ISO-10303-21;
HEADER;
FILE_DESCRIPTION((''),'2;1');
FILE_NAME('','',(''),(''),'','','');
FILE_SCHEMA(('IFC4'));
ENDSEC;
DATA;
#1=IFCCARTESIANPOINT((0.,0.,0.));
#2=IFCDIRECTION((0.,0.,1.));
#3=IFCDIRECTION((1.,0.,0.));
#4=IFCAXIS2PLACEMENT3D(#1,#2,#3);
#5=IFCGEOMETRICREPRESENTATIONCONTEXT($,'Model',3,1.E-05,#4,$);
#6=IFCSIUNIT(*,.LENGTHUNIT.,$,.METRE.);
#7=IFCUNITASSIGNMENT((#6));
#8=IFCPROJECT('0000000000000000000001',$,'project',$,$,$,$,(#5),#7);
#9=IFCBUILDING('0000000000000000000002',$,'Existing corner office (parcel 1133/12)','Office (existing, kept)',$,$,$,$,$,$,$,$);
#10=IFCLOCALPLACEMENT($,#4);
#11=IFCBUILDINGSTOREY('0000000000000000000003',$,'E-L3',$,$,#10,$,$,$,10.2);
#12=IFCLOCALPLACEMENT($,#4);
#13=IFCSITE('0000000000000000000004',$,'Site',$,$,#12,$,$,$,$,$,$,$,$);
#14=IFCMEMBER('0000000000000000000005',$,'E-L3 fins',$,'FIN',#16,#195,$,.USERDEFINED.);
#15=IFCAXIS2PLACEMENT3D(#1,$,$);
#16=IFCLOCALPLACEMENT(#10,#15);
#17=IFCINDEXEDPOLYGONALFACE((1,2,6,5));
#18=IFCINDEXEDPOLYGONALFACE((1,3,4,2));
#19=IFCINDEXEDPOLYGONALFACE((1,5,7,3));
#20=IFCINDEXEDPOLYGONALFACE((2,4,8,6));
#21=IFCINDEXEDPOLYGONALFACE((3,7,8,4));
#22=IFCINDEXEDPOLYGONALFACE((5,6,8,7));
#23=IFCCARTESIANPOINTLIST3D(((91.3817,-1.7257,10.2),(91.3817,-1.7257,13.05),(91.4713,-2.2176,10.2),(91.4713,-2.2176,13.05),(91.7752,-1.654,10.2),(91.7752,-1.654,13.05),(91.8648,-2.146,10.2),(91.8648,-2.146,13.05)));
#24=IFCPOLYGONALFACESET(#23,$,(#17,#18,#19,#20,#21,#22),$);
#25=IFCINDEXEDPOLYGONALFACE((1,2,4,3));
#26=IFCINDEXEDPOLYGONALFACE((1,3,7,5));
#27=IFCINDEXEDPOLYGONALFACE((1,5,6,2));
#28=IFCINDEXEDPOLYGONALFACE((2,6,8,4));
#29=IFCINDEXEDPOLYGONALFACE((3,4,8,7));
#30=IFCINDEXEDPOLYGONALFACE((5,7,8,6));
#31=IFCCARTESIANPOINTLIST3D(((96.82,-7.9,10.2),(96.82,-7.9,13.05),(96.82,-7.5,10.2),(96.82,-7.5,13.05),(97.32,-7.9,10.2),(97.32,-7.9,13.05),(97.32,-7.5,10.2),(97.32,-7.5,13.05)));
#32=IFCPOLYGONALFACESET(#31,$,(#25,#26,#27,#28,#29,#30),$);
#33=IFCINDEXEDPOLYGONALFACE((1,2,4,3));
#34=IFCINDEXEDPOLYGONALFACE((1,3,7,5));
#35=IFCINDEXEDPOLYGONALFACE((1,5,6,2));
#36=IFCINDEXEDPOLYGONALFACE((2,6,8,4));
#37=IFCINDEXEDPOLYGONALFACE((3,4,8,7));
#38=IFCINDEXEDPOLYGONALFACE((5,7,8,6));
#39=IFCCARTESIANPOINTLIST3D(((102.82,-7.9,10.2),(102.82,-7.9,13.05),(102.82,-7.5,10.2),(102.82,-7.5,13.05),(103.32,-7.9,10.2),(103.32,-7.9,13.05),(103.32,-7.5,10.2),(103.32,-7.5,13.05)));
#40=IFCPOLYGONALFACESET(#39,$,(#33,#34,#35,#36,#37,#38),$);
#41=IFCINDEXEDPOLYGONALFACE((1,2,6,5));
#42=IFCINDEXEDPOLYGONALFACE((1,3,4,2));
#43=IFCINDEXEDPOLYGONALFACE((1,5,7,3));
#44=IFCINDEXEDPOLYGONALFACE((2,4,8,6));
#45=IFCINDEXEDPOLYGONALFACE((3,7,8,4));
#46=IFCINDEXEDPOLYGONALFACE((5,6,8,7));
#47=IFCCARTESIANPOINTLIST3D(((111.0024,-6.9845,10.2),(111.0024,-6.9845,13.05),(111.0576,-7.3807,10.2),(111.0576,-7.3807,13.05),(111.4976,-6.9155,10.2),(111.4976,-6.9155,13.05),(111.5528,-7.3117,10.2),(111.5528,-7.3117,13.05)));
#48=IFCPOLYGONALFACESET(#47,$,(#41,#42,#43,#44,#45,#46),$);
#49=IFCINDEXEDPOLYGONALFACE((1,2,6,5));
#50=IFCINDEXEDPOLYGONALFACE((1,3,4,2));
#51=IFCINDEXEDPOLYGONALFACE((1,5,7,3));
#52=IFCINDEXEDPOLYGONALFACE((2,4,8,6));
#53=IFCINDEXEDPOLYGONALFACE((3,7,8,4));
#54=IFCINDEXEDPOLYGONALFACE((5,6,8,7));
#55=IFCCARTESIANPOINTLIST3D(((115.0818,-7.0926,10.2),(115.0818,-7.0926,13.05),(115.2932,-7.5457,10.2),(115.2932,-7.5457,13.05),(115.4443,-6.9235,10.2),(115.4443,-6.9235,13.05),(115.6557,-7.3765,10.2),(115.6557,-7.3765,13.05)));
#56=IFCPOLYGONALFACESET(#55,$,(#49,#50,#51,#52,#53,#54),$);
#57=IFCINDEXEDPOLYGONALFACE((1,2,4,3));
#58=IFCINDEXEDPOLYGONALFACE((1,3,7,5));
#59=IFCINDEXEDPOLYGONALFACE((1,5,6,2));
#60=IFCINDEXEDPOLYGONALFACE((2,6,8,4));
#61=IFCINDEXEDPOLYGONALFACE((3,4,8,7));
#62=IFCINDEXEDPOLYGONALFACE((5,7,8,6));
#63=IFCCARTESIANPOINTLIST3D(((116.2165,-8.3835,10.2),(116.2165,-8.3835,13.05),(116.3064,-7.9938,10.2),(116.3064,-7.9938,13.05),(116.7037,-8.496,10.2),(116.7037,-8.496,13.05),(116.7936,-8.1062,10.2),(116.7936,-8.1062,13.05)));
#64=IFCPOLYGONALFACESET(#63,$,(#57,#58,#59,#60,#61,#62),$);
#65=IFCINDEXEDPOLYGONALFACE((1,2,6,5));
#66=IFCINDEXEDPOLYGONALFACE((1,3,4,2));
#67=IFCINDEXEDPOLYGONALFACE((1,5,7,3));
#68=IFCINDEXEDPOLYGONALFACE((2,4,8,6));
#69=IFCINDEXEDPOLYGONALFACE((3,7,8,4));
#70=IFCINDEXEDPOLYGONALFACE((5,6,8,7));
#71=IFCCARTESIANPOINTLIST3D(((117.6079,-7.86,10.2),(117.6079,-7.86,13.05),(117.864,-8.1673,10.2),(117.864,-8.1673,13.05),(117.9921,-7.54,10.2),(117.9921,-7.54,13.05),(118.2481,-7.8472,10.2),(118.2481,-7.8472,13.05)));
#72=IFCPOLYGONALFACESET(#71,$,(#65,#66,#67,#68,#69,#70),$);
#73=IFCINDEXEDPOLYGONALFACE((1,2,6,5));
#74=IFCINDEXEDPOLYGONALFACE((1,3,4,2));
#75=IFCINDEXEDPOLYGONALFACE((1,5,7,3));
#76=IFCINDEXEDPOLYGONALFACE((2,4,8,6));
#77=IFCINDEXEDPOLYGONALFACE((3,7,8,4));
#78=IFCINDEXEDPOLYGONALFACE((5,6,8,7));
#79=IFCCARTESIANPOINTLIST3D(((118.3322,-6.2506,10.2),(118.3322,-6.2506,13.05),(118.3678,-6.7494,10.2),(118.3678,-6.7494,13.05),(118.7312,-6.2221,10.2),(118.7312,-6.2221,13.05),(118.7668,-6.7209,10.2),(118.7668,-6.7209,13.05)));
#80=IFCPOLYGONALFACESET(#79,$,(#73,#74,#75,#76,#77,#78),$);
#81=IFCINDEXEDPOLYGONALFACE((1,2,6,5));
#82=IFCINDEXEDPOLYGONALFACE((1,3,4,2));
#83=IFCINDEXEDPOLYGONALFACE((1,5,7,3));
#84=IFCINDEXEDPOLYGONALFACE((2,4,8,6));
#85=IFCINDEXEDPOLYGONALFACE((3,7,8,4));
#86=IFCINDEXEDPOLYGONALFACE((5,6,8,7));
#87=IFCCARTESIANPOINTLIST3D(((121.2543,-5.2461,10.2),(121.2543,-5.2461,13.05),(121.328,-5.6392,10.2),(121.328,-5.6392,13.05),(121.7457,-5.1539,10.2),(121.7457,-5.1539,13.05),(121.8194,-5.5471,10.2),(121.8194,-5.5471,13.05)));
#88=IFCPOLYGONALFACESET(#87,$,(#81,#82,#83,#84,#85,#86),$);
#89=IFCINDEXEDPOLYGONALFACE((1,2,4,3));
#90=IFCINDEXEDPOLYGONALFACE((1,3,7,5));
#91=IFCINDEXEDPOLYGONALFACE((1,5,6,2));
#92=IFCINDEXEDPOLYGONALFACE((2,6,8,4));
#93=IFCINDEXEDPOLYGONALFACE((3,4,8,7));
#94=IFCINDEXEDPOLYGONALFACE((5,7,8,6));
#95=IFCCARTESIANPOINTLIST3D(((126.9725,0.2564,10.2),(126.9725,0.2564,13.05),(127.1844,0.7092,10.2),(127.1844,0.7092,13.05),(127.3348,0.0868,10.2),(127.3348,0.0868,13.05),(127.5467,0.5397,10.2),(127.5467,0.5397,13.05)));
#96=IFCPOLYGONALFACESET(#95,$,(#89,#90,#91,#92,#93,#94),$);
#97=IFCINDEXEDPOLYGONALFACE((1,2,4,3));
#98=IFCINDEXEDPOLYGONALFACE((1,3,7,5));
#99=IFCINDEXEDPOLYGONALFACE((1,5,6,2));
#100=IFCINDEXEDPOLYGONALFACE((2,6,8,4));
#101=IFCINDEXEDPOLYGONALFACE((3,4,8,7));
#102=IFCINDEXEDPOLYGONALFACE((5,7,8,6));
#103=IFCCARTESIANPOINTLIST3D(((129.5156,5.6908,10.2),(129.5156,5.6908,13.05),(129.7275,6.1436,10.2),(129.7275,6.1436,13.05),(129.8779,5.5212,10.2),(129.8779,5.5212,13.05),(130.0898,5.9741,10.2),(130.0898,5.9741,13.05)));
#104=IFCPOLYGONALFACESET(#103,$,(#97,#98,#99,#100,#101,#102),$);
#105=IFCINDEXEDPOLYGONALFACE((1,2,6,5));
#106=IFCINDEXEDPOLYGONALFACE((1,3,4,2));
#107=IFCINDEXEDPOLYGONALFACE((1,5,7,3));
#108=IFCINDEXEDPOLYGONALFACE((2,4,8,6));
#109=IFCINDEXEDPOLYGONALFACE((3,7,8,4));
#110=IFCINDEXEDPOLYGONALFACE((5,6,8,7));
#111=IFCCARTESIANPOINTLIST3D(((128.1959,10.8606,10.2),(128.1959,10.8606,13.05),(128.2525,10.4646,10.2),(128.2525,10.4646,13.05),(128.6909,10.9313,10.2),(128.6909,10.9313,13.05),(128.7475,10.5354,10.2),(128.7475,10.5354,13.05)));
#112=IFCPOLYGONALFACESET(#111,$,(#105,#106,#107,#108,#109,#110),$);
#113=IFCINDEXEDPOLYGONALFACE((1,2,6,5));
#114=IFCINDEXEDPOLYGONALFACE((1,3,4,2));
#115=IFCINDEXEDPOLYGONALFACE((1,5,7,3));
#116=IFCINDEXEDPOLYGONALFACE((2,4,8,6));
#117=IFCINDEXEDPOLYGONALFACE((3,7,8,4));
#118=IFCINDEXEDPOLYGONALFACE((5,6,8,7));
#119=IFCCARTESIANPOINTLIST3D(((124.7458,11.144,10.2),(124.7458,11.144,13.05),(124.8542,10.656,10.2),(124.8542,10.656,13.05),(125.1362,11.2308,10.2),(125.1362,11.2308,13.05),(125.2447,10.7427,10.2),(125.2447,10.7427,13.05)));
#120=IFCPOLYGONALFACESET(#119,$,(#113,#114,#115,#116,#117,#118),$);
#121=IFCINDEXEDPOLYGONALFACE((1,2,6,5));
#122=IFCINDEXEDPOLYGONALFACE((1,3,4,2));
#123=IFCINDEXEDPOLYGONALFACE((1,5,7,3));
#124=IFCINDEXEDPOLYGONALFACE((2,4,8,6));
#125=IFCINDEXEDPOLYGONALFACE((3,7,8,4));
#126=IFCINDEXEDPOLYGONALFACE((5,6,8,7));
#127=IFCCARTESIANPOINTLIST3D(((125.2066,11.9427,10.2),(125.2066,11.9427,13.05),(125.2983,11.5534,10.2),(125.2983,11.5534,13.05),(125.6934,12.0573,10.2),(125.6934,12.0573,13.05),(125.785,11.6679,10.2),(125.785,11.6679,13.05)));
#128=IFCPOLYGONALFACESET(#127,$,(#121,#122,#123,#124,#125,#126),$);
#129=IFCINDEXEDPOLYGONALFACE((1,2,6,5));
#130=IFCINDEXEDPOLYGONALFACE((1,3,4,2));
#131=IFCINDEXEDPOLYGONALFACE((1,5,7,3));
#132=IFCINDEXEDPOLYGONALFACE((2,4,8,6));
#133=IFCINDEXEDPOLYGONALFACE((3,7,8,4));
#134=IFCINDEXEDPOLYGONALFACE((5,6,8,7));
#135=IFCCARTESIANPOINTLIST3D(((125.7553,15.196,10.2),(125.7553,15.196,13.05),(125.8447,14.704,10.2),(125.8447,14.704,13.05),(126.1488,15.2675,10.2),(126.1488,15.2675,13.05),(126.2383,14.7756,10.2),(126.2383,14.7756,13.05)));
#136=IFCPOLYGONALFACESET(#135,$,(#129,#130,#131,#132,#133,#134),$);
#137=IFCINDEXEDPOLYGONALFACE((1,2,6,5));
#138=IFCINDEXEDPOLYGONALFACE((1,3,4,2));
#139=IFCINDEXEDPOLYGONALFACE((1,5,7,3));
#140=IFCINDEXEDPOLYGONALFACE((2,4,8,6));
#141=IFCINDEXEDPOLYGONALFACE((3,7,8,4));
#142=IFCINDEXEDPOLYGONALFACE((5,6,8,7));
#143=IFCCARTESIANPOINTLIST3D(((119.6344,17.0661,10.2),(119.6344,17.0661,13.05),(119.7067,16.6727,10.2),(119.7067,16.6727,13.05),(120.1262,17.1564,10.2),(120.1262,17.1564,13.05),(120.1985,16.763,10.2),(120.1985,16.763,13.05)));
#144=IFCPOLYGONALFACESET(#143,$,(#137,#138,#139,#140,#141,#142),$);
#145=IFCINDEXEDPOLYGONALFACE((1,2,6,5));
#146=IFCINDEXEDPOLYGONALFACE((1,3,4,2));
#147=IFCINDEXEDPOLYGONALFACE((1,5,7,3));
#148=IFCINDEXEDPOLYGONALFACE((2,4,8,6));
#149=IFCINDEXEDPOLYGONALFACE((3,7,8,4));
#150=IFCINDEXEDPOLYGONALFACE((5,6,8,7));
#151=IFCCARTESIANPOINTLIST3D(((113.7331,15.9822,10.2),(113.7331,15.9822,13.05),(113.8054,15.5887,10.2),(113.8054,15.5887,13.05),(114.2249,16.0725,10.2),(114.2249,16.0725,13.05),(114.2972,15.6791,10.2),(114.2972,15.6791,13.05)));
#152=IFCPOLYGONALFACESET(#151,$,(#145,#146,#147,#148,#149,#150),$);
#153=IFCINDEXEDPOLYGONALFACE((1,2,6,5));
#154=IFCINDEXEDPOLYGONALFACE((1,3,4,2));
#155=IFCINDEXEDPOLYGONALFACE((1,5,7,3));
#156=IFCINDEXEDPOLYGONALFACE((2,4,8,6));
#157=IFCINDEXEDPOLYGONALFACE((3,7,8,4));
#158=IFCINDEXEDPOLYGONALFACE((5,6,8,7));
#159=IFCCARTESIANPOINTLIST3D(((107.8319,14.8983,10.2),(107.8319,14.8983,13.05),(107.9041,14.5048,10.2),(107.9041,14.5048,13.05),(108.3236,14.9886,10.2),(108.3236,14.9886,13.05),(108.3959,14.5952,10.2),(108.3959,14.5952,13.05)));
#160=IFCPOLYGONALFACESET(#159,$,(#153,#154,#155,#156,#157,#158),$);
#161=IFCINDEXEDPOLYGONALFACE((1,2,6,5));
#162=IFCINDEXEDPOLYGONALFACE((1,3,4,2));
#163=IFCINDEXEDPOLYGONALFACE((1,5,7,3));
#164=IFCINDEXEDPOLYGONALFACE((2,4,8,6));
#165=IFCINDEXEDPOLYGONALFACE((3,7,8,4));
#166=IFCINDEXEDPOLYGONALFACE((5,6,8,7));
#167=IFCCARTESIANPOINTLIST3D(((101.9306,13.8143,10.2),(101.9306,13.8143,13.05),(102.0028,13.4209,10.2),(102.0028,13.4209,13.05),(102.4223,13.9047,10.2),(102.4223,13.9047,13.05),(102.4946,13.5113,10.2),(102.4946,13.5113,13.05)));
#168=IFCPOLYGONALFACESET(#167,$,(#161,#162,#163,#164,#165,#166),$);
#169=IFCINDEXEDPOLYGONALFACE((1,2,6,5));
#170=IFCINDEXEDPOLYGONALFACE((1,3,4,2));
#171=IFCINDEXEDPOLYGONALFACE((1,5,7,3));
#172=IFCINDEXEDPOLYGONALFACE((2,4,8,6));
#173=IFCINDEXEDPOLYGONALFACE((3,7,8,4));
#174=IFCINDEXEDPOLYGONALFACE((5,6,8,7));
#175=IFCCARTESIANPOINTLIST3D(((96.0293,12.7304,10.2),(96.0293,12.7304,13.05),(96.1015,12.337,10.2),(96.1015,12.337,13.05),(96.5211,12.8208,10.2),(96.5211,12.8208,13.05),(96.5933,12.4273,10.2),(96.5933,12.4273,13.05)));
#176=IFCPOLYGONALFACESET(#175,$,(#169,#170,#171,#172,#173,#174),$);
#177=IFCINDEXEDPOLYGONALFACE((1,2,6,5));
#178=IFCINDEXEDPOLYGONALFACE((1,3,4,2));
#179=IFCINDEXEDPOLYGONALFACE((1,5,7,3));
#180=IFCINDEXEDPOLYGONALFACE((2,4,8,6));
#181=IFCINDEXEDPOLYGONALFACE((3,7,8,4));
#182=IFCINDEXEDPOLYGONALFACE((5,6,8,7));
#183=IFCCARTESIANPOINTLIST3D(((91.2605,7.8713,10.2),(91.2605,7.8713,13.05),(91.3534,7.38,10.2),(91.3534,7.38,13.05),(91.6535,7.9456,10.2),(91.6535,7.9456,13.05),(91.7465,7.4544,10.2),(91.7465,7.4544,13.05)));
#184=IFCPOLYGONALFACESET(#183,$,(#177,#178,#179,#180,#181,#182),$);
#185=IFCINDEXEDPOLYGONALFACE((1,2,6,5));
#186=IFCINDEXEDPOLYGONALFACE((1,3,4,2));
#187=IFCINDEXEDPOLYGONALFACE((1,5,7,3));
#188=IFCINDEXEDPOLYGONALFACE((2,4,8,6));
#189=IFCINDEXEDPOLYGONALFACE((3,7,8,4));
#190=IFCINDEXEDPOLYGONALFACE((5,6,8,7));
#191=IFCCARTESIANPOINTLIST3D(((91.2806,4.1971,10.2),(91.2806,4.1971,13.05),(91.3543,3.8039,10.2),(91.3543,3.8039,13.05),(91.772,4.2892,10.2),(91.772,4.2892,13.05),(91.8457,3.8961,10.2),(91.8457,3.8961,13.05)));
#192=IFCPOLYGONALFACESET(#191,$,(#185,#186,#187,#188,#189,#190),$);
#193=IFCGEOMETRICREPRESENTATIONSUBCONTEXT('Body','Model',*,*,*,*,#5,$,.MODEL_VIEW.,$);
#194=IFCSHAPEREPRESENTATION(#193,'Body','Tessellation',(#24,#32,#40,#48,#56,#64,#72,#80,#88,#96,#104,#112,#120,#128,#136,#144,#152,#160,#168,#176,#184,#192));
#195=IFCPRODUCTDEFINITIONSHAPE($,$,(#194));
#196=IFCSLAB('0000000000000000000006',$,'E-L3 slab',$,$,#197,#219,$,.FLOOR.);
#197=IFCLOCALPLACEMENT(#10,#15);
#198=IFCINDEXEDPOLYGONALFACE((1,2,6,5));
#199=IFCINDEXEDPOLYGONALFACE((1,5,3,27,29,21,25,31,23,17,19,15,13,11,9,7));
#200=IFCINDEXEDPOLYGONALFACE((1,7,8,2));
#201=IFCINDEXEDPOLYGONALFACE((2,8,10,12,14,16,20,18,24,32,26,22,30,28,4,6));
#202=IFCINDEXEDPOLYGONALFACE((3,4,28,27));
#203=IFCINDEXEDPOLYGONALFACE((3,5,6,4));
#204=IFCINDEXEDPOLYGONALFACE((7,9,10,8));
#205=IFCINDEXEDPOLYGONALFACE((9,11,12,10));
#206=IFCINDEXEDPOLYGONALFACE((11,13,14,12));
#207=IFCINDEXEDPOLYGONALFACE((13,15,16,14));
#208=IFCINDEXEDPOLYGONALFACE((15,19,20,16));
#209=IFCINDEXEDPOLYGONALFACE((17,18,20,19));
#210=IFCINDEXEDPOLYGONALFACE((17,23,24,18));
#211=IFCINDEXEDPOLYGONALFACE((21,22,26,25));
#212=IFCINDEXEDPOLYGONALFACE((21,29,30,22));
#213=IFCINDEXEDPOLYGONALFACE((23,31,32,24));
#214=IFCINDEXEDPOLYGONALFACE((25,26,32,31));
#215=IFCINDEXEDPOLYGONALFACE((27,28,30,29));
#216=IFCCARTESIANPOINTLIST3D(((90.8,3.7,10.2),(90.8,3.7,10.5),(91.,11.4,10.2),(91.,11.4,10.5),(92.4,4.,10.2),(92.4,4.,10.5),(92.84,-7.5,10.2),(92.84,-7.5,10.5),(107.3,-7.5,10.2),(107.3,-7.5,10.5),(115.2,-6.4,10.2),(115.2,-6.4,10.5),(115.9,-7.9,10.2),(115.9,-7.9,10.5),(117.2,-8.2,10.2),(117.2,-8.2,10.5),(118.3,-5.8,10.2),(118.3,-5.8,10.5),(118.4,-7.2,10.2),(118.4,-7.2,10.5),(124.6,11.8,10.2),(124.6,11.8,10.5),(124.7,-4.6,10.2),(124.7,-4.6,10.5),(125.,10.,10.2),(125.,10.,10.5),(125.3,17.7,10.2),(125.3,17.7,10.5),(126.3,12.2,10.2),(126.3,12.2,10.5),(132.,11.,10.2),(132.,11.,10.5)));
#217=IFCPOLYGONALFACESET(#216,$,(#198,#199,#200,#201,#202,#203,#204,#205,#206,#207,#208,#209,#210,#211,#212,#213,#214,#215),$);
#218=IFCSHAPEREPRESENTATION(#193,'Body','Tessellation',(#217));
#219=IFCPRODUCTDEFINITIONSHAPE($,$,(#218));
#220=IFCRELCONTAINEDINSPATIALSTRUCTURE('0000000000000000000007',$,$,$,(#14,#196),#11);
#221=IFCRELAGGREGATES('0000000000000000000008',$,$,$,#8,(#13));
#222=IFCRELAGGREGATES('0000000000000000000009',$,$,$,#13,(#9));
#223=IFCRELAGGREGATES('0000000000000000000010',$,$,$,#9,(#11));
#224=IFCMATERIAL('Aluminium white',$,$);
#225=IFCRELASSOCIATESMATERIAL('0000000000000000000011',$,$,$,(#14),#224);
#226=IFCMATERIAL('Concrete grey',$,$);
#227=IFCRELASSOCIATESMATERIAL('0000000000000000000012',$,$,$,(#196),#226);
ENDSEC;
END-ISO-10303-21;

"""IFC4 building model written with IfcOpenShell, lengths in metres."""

from ifc_helpers import new_model, si_unit, frame, origin_with_axes, place, context, subcontext, project, spatial, polyline, outline, extrude, material, element, save


model = new_model("IFC4")

# Units and contexts
model_context = context("Model", 3, precision=1e-05, world=origin_with_axes())
body_context = subcontext(model_context, "Body", "Model", "MODEL_VIEW")
ifc_project = project(units=[si_unit("LENGTHUNIT", "METRE")], contexts=[model_context])

# Site, building, storey
site_placement = place(None, origin_with_axes())
site = spatial("IfcSite", under=ifc_project, at=site_placement, Name="Site")
building = spatial("IfcBuilding", under=site, Name="Existing corner office (parcel 1133/12)", Description="Office (existing, kept)")
storey_placement = place(None, origin_with_axes())
storey = spatial("IfcBuildingStorey", under=building, at=storey_placement, Name="E-L3", Elevation=10.2)

# Member
ifc_material_1 = material(Name="Aluminium white")
member_1_placement = place(storey_placement, origin_with_axes())
element("IfcMember", 1, at=member_1_placement, inside=storey, material=ifc_material_1, Name="E-L3 fins", ObjectType="FIN", PredefinedType="USERDEFINED", context=body_context, shape_type="SweptSolid", body=[
    extrude(outline(polyline([(-0.2, -0.25), (0.2, -0.25), (0.2, 0.25), (-0.2, 0.25), (-0.2, -0.25)])), frame((91.6232, -1.9358, 10.2), z_axis=(0.0, 0.0, 1.0), x_axis=(-0.983814, -0.179195, 0.0)), (0.0, 0.0, 1.0), 2.85),
    extrude(outline(polyline([(-0.2, -0.25), (0.2, -0.25), (0.2, 0.25), (-0.2, 0.25), (-0.2, -0.25)])), frame((97.07, -7.7, 10.2), z_axis=(0.0, 0.0, 1.0), x_axis=(0.0, -1.0, 0.0)), (0.0, 0.0, 1.0), 2.85),
    extrude(outline(polyline([(-0.2, -0.25), (0.2, -0.25), (0.2, 0.25), (-0.2, 0.25), (-0.2, -0.25)])), frame((103.07, -7.7, 10.2), z_axis=(0.0, 0.0, 1.0), x_axis=(0.0, -1.0, 0.0)), (0.0, 0.0, 1.0), 2.85),
    extrude(outline(polyline([(-0.2, -0.25), (0.2, -0.25), (0.2, 0.25), (-0.2, 0.25), (-0.2, -0.25)])), frame((111.2776, -7.1481, 10.2), z_axis=(0.0, 0.0, 1.0), x_axis=(0.13791, -0.990445, 0.0)), (0.0, 0.0, 1.0), 2.85),
    extrude(outline(polyline([(-0.2, -0.25), (0.2, -0.25), (0.2, 0.25), (-0.2, 0.25), (-0.2, -0.25)])), frame((115.3688, -7.2346, 10.2), z_axis=(0.0, 0.0, 1.0), x_axis=(-0.906183, -0.422885, 0.0)), (0.0, 0.0, 1.0), 2.85),
    extrude(outline(polyline([(-0.2, -0.25), (0.2, -0.25), (0.2, 0.25), (-0.2, 0.25), (-0.2, -0.25)])), frame((116.505, -8.2449, 10.2), z_axis=(0.0, 0.0, 1.0), x_axis=(-0.22486, -0.974391, 0.0)), (0.0, 0.0, 1.0), 2.85),
    extrude(outline(polyline([(-0.2, -0.25), (0.2, -0.25), (0.2, 0.25), (-0.2, 0.25), (-0.2, -0.25)])), frame((117.928, -7.8536, 10.2), z_axis=(0.0, 0.0, 1.0), x_axis=(0.640184, -0.768221, 0.0)), (0.0, 0.0, 1.0), 2.85),
    extrude(outline(polyline([(-0.2, -0.25), (0.2, -0.25), (0.2, 0.25), (-0.2, 0.25), (-0.2, -0.25)])), frame((118.5495, -6.4858, 10.2), z_axis=(0.0, 0.0, 1.0), x_axis=(0.997459, 0.071247, 0.0)), (0.0, 0.0, 1.0), 2.85),
    extrude(outline(polyline([(-0.2, -0.25), (0.2, -0.25), (0.2, 0.25), (-0.2, 0.25), (-0.2, -0.25)])), frame((121.5369, -5.3966, 10.2), z_axis=(0.0, 0.0, 1.0), x_axis=(0.184289, -0.982872, 0.0)), (0.0, 0.0, 1.0), 2.85),
    extrude(outline(polyline([(-0.2, -0.25), (0.2, -0.25), (0.2, 0.25), (-0.2, 0.25), (-0.2, -0.25)])), frame((127.2596, 0.398, 10.2), z_axis=(0.0, 0.0, 1.0), x_axis=(0.905738, -0.423839, 0.0)), (0.0, 0.0, 1.0), 2.85),
    extrude(outline(polyline([(-0.2, -0.25), (0.2, -0.25), (0.2, 0.25), (-0.2, 0.25), (-0.2, -0.25)])), frame((129.8027, 5.8324, 10.2), z_axis=(0.0, 0.0, 1.0), x_axis=(0.905738, -0.423839, 0.0)), (0.0, 0.0, 1.0), 2.85),
    extrude(outline(polyline([(-0.2, -0.25), (0.2, -0.25), (0.2, 0.25), (-0.2, 0.25), (-0.2, -0.25)])), frame((128.4717, 10.698, 10.2), z_axis=(0.0, 0.0, 1.0), x_axis=(-0.141421, 0.989949, 0.0)), (0.0, 0.0, 1.0), 2.85),
    extrude(outline(polyline([(-0.2, -0.25), (0.2, -0.25), (0.2, 0.25), (-0.2, 0.25), (-0.2, -0.25)])), frame((124.9952, 10.9434, 10.2), z_axis=(0.0, 0.0, 1.0), x_axis=(0.976187, 0.21693, 0.0)), (0.0, 0.0, 1.0), 2.85),
    extrude(outline(polyline([(-0.2, -0.25), (0.2, -0.25), (0.2, 0.25), (-0.2, 0.25), (-0.2, -0.25)])), frame((125.4958, 11.8053, 10.2), z_axis=(0.0, 0.0, 1.0), x_axis=(0.229039, -0.973417, 0.0)), (0.0, 0.0, 1.0), 2.85),
    extrude(outline(polyline([(-0.2, -0.25), (0.2, -0.25), (0.2, 0.25), (-0.2, 0.25), (-0.2, -0.25)])), frame((125.9968, 14.9858, 10.2), z_axis=(0.0, 0.0, 1.0), x_axis=(0.98387, 0.178885, 0.0)), (0.0, 0.0, 1.0), 2.85),
    extrude(outline(polyline([(-0.2, -0.25), (0.2, -0.25), (0.2, 0.25), (-0.2, 0.25), (-0.2, -0.25)])), frame((119.9164, 16.9145, 10.2), z_axis=(0.0, 0.0, 1.0), x_axis=(-0.180652, 0.983547, 0.0)), (0.0, 0.0, 1.0), 2.85),
    extrude(outline(polyline([(-0.2, -0.25), (0.2, -0.25), (0.2, 0.25), (-0.2, 0.25), (-0.2, -0.25)])), frame((114.0152, 15.8306, 10.2), z_axis=(0.0, 0.0, 1.0), x_axis=(-0.180652, 0.983547, 0.0)), (0.0, 0.0, 1.0), 2.85),
    extrude(outline(polyline([(-0.2, -0.25), (0.2, -0.25), (0.2, 0.25), (-0.2, 0.25), (-0.2, -0.25)])), frame((108.1139, 14.7467, 10.2), z_axis=(0.0, 0.0, 1.0), x_axis=(-0.180652, 0.983547, 0.0)), (0.0, 0.0, 1.0), 2.85),
    extrude(outline(polyline([(-0.2, -0.25), (0.2, -0.25), (0.2, 0.25), (-0.2, 0.25), (-0.2, -0.25)])), frame((102.2126, 13.6628, 10.2), z_axis=(0.0, 0.0, 1.0), x_axis=(-0.180652, 0.983547, 0.0)), (0.0, 0.0, 1.0), 2.85),
    extrude(outline(polyline([(-0.2, -0.25), (0.2, -0.25), (0.2, 0.25), (-0.2, 0.25), (-0.2, -0.25)])), frame((96.3113, 12.5789, 10.2), z_axis=(0.0, 0.0, 1.0), x_axis=(-0.180652, 0.983547, 0.0)), (0.0, 0.0, 1.0), 2.85),
    extrude(outline(polyline([(-0.2, -0.25), (0.2, -0.25), (0.2, 0.25), (-0.2, 0.25), (-0.2, -0.25)])), frame((91.5035, 7.6628, 10.2), z_axis=(0.0, 0.0, 1.0), x_axis=(-0.98257, -0.185892, 0.0)), (0.0, 0.0, 1.0), 2.85),
    extrude(outline(polyline([(-0.2, -0.25), (0.2, -0.25), (0.2, 0.25), (-0.2, 0.25), (-0.2, -0.25)])), frame((91.5631, 4.0466, 10.2), z_axis=(0.0, 0.0, 1.0), x_axis=(-0.184289, 0.982872, 0.0)), (0.0, 0.0, 1.0), 2.85),
])

# Slab
ifc_material_2 = material(Name="Concrete grey")
slab_1_placement = place(storey_placement, origin_with_axes())
element("IfcSlab", 2, at=slab_1_placement, inside=storey, material=ifc_material_2, Name="E-L3 slab", PredefinedType="FLOOR", context=body_context, shape_type="SweptSolid", body=[
    extrude(outline(polyline([(90.8, 3.7), (92.84, -7.5), (107.3, -7.5), (115.2, -6.4), (115.9, -7.9), (117.2, -8.2), (118.4, -7.2), (118.3, -5.8), (124.7, -4.6), (132.0, 11.0), (125.0, 10.0), (124.6, 11.8), (126.3, 12.2), (125.3, 17.7), (91.0, 11.4), (92.4, 4.0), (90.8, 3.7)])), frame((0.0, 0.0, 10.2), z_axis=(0.0, 0.0, 1.0), x_axis=(1.0, 0.0, 0.0)), (0.0, 0.0, 1.0), 0.3),
])

save(model, "model.ifc")
